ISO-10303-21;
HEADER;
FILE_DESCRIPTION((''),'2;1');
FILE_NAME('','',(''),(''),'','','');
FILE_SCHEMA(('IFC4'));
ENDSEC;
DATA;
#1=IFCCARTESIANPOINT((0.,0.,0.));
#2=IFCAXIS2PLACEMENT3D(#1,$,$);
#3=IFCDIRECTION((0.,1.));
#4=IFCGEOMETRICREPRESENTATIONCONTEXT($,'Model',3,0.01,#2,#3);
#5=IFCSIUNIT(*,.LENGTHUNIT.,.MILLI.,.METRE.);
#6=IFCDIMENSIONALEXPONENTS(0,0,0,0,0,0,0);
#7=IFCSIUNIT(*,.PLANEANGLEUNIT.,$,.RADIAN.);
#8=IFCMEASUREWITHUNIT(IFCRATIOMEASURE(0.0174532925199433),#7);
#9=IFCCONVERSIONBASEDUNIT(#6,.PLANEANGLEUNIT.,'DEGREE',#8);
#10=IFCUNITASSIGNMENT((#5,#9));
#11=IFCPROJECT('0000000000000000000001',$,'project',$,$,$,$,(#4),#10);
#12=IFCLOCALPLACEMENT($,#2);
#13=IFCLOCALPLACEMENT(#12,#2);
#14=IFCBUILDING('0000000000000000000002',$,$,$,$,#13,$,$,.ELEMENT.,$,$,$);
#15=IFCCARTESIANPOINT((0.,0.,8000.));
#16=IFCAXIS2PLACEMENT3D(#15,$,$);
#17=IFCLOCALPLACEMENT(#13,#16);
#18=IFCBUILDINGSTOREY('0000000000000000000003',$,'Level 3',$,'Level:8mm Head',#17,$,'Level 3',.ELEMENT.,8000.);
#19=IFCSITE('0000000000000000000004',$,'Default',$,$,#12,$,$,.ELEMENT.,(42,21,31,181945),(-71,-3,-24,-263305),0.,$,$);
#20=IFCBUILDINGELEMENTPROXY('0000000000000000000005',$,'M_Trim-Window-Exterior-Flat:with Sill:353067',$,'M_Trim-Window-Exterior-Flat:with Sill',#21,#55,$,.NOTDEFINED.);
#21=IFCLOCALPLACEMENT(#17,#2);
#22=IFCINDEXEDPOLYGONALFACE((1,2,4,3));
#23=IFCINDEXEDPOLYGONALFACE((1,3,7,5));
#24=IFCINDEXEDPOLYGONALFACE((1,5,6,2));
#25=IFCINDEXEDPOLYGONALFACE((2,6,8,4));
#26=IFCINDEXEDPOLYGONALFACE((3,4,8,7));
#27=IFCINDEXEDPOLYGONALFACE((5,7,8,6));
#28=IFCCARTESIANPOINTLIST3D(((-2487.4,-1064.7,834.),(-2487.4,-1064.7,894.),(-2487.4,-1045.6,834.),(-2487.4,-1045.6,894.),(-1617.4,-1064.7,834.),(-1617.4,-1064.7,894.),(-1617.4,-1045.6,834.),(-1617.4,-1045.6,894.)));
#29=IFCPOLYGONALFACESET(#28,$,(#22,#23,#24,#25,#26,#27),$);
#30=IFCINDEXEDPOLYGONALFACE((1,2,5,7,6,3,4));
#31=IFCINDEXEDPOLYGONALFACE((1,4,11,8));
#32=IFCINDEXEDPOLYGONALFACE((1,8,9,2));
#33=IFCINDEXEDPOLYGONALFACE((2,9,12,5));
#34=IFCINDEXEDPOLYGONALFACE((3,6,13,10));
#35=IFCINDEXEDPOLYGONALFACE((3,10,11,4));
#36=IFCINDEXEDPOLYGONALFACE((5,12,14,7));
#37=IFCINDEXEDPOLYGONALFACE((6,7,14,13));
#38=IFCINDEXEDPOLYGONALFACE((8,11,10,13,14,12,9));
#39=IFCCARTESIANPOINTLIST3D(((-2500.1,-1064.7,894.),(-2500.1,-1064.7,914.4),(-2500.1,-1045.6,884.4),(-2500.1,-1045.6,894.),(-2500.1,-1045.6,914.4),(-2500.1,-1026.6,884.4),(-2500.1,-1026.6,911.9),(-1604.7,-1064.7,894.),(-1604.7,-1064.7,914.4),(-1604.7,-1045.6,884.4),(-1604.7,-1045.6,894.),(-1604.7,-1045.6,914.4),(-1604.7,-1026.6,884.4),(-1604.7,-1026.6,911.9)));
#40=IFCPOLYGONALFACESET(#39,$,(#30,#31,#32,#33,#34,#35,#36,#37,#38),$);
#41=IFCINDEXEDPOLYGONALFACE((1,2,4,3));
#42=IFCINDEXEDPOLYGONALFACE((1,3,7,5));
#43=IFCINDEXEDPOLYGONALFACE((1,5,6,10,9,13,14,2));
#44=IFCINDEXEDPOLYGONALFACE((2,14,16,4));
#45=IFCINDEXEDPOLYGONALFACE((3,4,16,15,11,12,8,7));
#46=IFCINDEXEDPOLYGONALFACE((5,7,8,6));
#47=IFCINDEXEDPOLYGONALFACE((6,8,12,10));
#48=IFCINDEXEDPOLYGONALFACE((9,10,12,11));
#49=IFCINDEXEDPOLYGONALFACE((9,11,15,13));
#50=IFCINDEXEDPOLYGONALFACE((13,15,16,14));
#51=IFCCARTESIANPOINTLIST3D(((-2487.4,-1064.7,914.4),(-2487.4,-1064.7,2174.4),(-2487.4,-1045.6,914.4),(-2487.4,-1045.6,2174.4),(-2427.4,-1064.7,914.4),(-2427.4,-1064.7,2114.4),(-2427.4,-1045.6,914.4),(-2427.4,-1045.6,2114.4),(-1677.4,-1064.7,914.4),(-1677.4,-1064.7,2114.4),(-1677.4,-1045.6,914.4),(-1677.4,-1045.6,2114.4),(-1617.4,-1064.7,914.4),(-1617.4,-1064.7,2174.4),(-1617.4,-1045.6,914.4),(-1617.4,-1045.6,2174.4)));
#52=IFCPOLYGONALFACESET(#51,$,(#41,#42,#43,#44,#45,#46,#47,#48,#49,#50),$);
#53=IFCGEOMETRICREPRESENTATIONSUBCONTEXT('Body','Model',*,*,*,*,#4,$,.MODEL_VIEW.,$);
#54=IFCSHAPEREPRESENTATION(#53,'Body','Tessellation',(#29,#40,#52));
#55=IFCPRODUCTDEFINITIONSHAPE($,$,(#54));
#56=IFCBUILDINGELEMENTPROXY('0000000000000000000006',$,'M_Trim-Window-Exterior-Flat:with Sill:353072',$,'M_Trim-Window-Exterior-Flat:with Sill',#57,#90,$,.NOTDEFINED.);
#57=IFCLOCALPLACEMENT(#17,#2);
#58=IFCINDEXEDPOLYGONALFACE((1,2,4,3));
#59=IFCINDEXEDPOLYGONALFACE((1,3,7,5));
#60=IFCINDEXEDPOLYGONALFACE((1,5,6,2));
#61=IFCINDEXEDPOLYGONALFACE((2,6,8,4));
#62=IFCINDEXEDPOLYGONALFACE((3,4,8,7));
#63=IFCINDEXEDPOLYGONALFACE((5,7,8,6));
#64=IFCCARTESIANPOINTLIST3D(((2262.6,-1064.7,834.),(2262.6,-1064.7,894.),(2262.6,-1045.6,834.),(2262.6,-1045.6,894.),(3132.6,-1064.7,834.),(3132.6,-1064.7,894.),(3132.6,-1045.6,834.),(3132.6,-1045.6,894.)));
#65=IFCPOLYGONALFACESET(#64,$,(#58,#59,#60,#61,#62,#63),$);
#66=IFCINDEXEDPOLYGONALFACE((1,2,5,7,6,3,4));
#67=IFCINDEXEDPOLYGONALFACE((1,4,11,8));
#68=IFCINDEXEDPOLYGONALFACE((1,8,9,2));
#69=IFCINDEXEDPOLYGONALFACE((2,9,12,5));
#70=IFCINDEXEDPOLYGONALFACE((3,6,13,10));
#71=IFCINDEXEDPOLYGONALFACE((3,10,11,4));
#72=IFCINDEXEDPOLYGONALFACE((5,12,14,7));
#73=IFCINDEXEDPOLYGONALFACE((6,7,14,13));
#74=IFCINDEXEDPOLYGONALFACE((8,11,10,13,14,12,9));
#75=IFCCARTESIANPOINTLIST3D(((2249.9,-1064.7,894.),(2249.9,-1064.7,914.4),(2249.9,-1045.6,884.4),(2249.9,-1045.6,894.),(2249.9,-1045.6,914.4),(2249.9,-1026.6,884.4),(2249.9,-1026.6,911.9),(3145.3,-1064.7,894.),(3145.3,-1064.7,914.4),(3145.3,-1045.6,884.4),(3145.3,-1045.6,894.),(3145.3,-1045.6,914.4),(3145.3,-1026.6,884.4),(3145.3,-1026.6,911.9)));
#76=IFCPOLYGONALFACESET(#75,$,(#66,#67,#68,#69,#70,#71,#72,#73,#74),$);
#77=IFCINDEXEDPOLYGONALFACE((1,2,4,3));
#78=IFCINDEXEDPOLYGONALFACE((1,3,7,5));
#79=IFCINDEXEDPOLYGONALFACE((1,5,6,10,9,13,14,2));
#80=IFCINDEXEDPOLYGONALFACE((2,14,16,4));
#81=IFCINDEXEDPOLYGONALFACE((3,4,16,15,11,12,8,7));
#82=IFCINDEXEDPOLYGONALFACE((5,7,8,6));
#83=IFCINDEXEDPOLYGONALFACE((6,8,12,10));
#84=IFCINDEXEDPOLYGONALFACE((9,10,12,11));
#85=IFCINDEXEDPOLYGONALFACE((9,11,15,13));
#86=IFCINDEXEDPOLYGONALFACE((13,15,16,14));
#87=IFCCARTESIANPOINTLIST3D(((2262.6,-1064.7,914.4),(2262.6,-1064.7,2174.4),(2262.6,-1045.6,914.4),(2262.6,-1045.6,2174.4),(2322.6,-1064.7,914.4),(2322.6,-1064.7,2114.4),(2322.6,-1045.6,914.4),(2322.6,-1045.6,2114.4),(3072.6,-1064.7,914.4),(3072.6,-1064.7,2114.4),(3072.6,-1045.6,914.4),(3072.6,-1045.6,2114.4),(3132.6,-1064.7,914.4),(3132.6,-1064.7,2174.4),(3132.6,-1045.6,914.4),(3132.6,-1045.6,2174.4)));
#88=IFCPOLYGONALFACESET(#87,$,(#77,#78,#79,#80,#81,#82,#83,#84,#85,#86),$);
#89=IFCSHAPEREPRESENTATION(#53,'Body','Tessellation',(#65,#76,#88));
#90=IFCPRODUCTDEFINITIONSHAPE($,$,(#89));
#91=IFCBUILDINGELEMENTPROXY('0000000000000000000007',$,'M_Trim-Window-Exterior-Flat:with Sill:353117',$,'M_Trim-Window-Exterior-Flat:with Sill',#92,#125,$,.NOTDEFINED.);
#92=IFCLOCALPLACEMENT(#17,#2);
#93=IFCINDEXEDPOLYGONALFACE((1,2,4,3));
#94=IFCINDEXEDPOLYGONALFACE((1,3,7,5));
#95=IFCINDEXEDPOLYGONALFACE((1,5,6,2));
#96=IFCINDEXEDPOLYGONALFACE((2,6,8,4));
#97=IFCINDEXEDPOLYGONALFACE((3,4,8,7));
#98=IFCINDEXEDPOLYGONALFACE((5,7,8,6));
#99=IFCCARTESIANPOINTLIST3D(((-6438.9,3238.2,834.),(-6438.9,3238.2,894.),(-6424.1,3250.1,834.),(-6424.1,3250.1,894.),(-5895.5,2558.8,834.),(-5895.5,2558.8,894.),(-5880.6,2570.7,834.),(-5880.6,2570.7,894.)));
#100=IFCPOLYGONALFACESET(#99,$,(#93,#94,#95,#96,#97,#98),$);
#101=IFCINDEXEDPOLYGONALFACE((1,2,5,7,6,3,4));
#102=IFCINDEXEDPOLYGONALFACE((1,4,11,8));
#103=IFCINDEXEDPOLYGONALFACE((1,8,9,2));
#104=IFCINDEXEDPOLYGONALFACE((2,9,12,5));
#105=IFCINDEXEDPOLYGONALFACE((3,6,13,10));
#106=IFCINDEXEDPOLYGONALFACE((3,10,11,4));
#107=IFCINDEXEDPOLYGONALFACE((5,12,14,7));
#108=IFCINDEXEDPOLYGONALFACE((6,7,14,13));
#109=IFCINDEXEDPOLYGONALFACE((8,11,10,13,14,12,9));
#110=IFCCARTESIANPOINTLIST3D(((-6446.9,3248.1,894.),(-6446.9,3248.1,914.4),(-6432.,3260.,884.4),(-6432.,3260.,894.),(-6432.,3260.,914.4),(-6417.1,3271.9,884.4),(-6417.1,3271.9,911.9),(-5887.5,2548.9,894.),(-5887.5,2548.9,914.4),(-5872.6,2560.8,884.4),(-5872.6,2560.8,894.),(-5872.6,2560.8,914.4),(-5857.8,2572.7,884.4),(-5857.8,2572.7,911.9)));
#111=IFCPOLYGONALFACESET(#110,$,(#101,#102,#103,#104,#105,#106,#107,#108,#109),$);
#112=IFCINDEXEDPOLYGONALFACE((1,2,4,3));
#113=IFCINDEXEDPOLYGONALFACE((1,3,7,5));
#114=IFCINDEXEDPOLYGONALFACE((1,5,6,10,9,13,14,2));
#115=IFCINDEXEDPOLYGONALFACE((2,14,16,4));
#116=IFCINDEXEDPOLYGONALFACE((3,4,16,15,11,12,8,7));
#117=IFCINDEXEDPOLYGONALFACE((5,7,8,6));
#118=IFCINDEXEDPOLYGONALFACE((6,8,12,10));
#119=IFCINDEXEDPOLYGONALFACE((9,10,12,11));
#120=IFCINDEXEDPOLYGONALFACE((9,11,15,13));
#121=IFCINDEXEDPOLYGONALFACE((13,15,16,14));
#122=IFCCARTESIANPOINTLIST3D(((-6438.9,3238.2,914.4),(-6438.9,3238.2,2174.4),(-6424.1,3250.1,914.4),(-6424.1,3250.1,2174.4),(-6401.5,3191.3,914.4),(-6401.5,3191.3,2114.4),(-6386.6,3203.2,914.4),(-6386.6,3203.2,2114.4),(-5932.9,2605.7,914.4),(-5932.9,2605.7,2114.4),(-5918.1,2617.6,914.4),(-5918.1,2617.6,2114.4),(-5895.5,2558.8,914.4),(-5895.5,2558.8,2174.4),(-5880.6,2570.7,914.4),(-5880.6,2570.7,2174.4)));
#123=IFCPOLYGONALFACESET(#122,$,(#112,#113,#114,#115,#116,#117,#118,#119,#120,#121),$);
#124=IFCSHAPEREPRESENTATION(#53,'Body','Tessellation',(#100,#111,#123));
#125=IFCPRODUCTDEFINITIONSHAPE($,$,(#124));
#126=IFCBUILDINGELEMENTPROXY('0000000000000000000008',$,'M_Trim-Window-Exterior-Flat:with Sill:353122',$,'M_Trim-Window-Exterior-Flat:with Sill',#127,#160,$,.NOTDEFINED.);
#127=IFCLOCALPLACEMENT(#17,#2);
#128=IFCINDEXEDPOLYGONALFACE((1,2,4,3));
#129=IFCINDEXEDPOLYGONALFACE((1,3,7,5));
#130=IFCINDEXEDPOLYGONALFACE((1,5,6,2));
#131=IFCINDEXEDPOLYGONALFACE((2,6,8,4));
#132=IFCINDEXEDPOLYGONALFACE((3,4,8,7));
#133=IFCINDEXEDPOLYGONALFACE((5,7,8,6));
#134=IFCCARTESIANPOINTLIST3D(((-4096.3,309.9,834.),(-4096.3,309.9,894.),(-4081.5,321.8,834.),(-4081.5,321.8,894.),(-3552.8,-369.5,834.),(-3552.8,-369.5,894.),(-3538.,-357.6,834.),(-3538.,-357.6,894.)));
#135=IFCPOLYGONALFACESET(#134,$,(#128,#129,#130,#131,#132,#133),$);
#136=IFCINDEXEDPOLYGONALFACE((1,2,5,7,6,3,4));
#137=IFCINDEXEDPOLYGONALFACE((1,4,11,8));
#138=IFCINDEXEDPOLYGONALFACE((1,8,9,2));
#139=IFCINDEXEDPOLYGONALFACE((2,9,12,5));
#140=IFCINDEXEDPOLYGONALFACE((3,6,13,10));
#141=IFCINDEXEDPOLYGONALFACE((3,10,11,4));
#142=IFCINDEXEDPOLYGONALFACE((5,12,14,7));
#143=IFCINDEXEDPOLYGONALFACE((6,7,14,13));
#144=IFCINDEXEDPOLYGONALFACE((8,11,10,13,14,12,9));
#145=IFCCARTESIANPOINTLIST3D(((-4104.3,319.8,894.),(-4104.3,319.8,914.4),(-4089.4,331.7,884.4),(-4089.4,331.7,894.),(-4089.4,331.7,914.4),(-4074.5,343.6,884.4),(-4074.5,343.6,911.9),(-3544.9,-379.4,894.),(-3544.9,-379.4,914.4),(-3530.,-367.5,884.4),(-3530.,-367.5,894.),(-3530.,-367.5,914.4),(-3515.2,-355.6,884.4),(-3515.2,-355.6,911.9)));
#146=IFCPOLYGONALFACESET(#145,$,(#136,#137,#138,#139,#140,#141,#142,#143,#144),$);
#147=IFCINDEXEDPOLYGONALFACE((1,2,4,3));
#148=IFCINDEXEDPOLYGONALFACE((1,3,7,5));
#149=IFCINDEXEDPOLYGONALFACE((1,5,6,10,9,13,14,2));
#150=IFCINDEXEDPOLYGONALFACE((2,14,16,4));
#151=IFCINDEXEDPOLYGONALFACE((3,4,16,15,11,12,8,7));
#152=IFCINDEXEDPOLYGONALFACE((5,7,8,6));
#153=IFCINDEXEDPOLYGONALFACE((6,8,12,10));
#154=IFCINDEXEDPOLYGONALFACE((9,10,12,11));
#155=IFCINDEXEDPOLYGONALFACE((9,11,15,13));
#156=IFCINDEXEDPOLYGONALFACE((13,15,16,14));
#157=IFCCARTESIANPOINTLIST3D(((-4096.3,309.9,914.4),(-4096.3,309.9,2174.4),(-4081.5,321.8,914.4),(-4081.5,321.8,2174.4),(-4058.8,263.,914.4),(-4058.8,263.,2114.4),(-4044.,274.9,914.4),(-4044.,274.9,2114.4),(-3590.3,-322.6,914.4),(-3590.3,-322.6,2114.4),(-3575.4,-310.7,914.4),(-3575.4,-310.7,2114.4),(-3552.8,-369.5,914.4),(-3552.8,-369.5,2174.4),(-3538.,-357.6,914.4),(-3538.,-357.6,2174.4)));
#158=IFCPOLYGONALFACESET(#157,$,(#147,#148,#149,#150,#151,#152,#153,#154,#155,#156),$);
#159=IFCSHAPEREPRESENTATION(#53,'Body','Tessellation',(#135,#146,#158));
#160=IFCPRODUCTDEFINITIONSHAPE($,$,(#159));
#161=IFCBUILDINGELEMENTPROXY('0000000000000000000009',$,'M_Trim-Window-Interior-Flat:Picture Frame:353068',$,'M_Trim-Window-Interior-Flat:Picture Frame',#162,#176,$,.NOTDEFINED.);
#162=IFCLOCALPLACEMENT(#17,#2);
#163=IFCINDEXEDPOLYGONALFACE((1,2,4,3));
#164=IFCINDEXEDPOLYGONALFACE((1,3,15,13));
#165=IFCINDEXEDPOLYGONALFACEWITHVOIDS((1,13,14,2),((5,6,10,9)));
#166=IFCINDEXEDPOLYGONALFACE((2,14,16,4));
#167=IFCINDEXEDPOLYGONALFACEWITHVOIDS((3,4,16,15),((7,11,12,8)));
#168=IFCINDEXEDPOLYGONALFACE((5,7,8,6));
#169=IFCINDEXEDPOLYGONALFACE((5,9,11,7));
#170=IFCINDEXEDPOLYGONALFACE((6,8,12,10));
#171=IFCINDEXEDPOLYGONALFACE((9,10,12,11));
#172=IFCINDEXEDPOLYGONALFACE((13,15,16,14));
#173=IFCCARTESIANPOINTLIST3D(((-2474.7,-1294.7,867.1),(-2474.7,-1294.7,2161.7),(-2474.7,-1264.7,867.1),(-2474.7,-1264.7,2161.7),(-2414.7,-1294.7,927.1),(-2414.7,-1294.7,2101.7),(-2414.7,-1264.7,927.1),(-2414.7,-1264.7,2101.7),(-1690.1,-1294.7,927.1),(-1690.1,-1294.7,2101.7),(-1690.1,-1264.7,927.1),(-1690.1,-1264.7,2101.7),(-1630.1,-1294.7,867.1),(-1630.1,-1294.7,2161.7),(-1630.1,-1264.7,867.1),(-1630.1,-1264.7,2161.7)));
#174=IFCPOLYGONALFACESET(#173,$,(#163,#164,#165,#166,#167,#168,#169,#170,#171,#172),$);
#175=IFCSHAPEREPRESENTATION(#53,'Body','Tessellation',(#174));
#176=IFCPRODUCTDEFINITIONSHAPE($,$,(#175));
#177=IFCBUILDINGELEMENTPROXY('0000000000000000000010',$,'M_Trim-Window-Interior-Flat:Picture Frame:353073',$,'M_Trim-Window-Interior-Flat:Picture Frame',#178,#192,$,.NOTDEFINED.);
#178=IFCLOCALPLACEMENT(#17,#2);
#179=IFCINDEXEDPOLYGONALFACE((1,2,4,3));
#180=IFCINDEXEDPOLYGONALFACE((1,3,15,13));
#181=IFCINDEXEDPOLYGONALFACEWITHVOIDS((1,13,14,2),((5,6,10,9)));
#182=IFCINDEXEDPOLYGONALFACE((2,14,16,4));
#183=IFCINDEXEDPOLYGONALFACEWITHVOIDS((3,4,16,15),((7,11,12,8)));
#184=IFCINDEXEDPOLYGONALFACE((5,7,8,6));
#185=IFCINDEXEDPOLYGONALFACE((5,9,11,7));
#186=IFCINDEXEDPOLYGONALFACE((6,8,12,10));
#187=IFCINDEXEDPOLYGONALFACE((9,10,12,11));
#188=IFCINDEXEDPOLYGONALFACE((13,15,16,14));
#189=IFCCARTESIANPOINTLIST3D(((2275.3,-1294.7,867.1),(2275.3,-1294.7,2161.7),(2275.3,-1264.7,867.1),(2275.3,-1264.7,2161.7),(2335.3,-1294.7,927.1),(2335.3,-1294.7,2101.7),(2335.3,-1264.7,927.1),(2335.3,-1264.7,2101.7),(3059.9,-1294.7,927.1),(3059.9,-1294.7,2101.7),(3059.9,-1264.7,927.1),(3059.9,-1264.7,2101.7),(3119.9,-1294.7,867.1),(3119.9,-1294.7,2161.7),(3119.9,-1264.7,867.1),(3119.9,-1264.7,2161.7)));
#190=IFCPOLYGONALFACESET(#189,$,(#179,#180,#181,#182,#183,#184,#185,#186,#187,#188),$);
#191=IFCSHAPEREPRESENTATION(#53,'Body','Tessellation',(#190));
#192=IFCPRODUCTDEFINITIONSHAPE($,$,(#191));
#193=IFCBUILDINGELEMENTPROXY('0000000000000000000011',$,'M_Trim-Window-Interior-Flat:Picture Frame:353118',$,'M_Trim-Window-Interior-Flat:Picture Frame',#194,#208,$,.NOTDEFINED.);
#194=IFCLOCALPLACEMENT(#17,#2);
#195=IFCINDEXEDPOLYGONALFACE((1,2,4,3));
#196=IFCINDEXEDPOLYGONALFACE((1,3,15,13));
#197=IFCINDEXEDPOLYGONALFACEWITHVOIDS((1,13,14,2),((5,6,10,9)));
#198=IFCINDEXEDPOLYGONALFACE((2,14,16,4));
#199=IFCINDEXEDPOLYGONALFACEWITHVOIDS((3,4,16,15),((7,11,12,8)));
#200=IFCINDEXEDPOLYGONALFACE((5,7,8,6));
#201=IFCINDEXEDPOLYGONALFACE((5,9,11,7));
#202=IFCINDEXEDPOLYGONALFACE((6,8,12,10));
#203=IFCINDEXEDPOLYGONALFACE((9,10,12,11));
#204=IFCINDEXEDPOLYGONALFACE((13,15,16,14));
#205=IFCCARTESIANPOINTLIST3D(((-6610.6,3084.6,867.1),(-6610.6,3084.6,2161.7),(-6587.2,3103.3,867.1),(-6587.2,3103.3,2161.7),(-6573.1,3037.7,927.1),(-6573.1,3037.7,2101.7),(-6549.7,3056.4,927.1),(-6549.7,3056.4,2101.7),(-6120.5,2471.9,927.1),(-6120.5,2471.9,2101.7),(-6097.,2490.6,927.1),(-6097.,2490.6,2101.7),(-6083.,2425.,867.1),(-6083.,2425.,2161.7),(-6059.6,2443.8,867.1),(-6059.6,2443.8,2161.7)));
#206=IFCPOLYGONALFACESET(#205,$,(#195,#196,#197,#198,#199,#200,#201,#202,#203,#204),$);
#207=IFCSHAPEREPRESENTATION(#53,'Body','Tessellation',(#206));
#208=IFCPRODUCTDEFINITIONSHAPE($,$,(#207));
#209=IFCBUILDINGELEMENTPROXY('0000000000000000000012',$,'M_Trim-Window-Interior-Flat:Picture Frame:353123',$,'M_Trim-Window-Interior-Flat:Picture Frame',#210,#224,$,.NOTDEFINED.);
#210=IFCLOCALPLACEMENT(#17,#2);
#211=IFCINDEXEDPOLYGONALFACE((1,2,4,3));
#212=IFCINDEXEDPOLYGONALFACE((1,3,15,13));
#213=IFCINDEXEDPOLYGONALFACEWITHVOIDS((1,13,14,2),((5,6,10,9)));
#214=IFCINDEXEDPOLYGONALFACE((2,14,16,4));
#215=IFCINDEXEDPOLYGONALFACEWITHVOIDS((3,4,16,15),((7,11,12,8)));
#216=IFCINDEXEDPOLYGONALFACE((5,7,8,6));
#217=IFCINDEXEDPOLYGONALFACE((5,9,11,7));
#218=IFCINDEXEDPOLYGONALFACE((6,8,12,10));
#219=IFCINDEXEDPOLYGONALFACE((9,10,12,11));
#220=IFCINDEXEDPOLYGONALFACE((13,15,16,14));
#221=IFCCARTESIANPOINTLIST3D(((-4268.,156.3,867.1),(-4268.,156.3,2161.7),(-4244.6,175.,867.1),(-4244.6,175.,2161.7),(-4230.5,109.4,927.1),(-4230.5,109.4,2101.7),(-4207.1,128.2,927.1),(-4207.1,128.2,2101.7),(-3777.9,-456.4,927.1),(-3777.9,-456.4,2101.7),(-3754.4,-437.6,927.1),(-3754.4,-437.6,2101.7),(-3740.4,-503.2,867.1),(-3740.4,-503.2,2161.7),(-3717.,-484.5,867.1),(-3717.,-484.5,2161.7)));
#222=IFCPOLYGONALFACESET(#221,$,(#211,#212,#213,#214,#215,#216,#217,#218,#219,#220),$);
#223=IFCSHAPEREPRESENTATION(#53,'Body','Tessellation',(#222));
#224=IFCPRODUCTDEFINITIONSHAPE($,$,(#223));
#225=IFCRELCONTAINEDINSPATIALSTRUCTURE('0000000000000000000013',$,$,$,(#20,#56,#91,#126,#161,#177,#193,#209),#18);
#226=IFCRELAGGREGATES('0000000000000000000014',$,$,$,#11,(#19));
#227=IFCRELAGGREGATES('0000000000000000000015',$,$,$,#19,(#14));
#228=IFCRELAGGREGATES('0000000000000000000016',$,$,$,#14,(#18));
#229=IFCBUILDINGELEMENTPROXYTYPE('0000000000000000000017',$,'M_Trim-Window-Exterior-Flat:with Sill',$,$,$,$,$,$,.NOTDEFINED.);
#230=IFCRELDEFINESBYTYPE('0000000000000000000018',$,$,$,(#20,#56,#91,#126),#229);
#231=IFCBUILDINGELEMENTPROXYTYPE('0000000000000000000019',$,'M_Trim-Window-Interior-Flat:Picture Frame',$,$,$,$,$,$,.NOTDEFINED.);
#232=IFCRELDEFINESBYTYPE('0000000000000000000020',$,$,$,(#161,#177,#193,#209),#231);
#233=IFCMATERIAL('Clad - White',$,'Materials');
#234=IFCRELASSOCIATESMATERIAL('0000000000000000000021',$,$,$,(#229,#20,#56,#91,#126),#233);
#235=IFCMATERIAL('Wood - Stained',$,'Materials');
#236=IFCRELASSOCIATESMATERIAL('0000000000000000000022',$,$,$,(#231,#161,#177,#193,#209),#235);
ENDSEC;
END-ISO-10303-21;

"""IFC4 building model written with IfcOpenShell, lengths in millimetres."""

from ifc_helpers import new_model, entity, si_unit, converted_unit, direction, frame, frame_2d, origin, place, context, subcontext, project, spatial, polyline, rectangle, outline, extrude, source, transform, mapped, material, type_object, type_shapes, element, save


model = new_model("IFC4")

# Units and contexts
model_context = context("Model", 3, precision=0.01, world=origin(), true_north=direction((0.0, 1.0)))
body_context = subcontext(model_context, "Body", "Model", "MODEL_VIEW")
ifc_project = project(units=[si_unit("LENGTHUNIT", "METRE", prefix="MILLI"), converted_unit("PLANEANGLEUNIT", "DEGREE", entity("IfcRatioMeasure", 0.0174532925199433), si_unit("PLANEANGLEUNIT", "RADIAN"), dimensions=[0, 0, 0, 0, 0, 0, 0])], contexts=[model_context])

# Site, building, storey
site_placement = place(None, origin())
site = spatial("IfcSite", under=ifc_project, at=site_placement, Name="Default", CompositionType="ELEMENT", RefLatitude=(42, 21, 31, 181945), RefLongitude=(-71, -3, -24, -263305), RefElevation=0.0)
building_placement = place(site_placement, origin())
building = spatial("IfcBuilding", under=site, at=building_placement, CompositionType="ELEMENT")
storey_placement = place(building_placement, frame((0.0, 0.0, 8000.0)))
storey = spatial("IfcBuildingStorey", under=building, at=storey_placement, Name="Level 3", ObjectType="Level:8mm Head", LongName="Level 3", CompositionType="ELEMENT", Elevation=8000.0)

# Shared definitions
ifc_material_1 = material(Name="Wood - Stained", Category="Materials")

# Building element proxies
ifc_material_2 = material(Name="Clad - White", Category="Materials")
building_element_proxy_type_1 = type_object("IfcBuildingElementProxyType", Name="M_Trim-Window-Exterior-Flat:with Sill", PredefinedType="NOTDEFINED", material=ifc_material_2)
shared_shape_1 = source(origin(), body_context, "Body", "SweptSolid", [
    extrude(rectangle(XDim=870.0, YDim=60.0, at=frame_2d((0.0, 0.0), x_axis=(1.0, 0.0))), frame((0.0, -1250.4, 0.0), z_axis=(0.0, 0.0, 1.0), x_axis=(-1.0, 0.0, 0.0)), (0.0, 0.0, 1.0), 19.1),
    extrude(outline(polyline([(-19.0, -15.2), (0.0, -15.2), (0.0, -5.7), (19.0, -5.7), (19.0, 14.8), (0.0, 14.8), (-19.0, 12.3), (-19.0, -15.2)])), frame((-447.7, -1214.8, 19.0), z_axis=(1.0, 0.0, 0.0), x_axis=(0.0, 0.0, -1.0)), (0.0, 0.0, 1.0), 895.4),
    extrude(outline(polyline([(-645.0, -435.0), (615.0, -435.0), (615.0, -375.0), (-585.0, -375.0), (-585.0, 375.0), (615.0, 375.0), (615.0, 435.0), (-645.0, 435.0), (-645.0, -435.0)])), frame((0.0, -585.0, 0.0), z_axis=(0.0, 0.0, 1.0), x_axis=(0.0, -1.0, 0.0)), (0.0, 0.0, 1.0), 19.1),
])
type_shapes(building_element_proxy_type_1, [shared_shape_1])
for number, where, z_axis, x_axis, name in (
    (1, (-2052.4, -1064.7, 2114.4), (0.0, 1.0, 0.0), (-1.0, 0.0, 0.0), "M_Trim-Window-Exterior-Flat:with Sill:353067"),
    (2, (2697.6, -1064.7, 2114.4), (0.0, 1.0, 0.0), (-1.0, 0.0, 0.0), "M_Trim-Window-Exterior-Flat:with Sill:353072"),
    (3, (-6167.2, 2898.5, 2114.4), (0.780869, 0.624695, 0.0), (-0.624695, 0.780869, 0.0), "M_Trim-Window-Exterior-Flat:with Sill:353117"),
    (4, (-3824.6, -29.8, 2114.4), (0.780869, 0.624695, 0.0), (-0.624695, 0.780869, 0.0), "M_Trim-Window-Exterior-Flat:with Sill:353122"),
):
    element("IfcBuildingElementProxy", number, at=place(storey_placement, frame(where, z_axis=z_axis, x_axis=x_axis)), inside=storey, type_object=building_element_proxy_type_1, material=ifc_material_2, Name=name, ObjectType="M_Trim-Window-Exterior-Flat:with Sill", PredefinedType="NOTDEFINED", context=body_context, shape_type="MappedRepresentation", body=[
        mapped(shared_shape_1, transform((0.0, 0.0, 0.0), scale=1.0)),
    ])
building_element_proxy_type_2 = type_object("IfcBuildingElementProxyType", Name="M_Trim-Window-Interior-Flat:Picture Frame", PredefinedType="NOTDEFINED", material=ifc_material_1)
shared_shape_2 = source(origin(), body_context, "Body", "SweptSolid", [
    extrude(outline(polyline([(-422.3, -647.3), (422.3, -647.3), (422.3, 647.3), (-422.3, 647.3), (-422.3, -647.3)]), holes=[polyline([(-362.3, -587.3), (-362.3, 587.3), (362.3, 587.3), (362.3, -587.3), (-362.3, -587.3)])]), frame((0.0, -600.0, 0.0), z_axis=(0.0, 0.0, 1.0), x_axis=(-1.0, 0.0, 0.0)), (0.0, 0.0, 1.0), 30.0),
])
type_shapes(building_element_proxy_type_2, [shared_shape_2])
for number, where, z_axis, x_axis, name in (
    (5, (-2052.4, -1264.7, 2114.4), (0.0, -1.0, 0.0), (1.0, 0.0, 0.0), "M_Trim-Window-Interior-Flat:Picture Frame:353068"),
    (6, (2697.6, -1264.7, 2114.4), (0.0, -1.0, 0.0), (1.0, 0.0, 0.0), "M_Trim-Window-Interior-Flat:Picture Frame:353073"),
    (7, (-6323.4, 2773.5, 2114.4), (-0.780869, -0.624695, 0.0), (0.624695, -0.780869, 0.0), "M_Trim-Window-Interior-Flat:Picture Frame:353118"),
    (8, (-3980.8, -154.7, 2114.4), (-0.780869, -0.624695, 0.0), (0.624695, -0.780869, 0.0), "M_Trim-Window-Interior-Flat:Picture Frame:353123"),
):
    element("IfcBuildingElementProxy", number, at=place(storey_placement, frame(where, z_axis=z_axis, x_axis=x_axis)), inside=storey, type_object=building_element_proxy_type_2, material=ifc_material_1, Name=name, ObjectType="M_Trim-Window-Interior-Flat:Picture Frame", PredefinedType="NOTDEFINED", context=body_context, shape_type="MappedRepresentation", body=[
        mapped(shared_shape_2, transform((0.0, 0.0, 0.0), scale=1.0)),
    ])

save(model, "model.ifc")
